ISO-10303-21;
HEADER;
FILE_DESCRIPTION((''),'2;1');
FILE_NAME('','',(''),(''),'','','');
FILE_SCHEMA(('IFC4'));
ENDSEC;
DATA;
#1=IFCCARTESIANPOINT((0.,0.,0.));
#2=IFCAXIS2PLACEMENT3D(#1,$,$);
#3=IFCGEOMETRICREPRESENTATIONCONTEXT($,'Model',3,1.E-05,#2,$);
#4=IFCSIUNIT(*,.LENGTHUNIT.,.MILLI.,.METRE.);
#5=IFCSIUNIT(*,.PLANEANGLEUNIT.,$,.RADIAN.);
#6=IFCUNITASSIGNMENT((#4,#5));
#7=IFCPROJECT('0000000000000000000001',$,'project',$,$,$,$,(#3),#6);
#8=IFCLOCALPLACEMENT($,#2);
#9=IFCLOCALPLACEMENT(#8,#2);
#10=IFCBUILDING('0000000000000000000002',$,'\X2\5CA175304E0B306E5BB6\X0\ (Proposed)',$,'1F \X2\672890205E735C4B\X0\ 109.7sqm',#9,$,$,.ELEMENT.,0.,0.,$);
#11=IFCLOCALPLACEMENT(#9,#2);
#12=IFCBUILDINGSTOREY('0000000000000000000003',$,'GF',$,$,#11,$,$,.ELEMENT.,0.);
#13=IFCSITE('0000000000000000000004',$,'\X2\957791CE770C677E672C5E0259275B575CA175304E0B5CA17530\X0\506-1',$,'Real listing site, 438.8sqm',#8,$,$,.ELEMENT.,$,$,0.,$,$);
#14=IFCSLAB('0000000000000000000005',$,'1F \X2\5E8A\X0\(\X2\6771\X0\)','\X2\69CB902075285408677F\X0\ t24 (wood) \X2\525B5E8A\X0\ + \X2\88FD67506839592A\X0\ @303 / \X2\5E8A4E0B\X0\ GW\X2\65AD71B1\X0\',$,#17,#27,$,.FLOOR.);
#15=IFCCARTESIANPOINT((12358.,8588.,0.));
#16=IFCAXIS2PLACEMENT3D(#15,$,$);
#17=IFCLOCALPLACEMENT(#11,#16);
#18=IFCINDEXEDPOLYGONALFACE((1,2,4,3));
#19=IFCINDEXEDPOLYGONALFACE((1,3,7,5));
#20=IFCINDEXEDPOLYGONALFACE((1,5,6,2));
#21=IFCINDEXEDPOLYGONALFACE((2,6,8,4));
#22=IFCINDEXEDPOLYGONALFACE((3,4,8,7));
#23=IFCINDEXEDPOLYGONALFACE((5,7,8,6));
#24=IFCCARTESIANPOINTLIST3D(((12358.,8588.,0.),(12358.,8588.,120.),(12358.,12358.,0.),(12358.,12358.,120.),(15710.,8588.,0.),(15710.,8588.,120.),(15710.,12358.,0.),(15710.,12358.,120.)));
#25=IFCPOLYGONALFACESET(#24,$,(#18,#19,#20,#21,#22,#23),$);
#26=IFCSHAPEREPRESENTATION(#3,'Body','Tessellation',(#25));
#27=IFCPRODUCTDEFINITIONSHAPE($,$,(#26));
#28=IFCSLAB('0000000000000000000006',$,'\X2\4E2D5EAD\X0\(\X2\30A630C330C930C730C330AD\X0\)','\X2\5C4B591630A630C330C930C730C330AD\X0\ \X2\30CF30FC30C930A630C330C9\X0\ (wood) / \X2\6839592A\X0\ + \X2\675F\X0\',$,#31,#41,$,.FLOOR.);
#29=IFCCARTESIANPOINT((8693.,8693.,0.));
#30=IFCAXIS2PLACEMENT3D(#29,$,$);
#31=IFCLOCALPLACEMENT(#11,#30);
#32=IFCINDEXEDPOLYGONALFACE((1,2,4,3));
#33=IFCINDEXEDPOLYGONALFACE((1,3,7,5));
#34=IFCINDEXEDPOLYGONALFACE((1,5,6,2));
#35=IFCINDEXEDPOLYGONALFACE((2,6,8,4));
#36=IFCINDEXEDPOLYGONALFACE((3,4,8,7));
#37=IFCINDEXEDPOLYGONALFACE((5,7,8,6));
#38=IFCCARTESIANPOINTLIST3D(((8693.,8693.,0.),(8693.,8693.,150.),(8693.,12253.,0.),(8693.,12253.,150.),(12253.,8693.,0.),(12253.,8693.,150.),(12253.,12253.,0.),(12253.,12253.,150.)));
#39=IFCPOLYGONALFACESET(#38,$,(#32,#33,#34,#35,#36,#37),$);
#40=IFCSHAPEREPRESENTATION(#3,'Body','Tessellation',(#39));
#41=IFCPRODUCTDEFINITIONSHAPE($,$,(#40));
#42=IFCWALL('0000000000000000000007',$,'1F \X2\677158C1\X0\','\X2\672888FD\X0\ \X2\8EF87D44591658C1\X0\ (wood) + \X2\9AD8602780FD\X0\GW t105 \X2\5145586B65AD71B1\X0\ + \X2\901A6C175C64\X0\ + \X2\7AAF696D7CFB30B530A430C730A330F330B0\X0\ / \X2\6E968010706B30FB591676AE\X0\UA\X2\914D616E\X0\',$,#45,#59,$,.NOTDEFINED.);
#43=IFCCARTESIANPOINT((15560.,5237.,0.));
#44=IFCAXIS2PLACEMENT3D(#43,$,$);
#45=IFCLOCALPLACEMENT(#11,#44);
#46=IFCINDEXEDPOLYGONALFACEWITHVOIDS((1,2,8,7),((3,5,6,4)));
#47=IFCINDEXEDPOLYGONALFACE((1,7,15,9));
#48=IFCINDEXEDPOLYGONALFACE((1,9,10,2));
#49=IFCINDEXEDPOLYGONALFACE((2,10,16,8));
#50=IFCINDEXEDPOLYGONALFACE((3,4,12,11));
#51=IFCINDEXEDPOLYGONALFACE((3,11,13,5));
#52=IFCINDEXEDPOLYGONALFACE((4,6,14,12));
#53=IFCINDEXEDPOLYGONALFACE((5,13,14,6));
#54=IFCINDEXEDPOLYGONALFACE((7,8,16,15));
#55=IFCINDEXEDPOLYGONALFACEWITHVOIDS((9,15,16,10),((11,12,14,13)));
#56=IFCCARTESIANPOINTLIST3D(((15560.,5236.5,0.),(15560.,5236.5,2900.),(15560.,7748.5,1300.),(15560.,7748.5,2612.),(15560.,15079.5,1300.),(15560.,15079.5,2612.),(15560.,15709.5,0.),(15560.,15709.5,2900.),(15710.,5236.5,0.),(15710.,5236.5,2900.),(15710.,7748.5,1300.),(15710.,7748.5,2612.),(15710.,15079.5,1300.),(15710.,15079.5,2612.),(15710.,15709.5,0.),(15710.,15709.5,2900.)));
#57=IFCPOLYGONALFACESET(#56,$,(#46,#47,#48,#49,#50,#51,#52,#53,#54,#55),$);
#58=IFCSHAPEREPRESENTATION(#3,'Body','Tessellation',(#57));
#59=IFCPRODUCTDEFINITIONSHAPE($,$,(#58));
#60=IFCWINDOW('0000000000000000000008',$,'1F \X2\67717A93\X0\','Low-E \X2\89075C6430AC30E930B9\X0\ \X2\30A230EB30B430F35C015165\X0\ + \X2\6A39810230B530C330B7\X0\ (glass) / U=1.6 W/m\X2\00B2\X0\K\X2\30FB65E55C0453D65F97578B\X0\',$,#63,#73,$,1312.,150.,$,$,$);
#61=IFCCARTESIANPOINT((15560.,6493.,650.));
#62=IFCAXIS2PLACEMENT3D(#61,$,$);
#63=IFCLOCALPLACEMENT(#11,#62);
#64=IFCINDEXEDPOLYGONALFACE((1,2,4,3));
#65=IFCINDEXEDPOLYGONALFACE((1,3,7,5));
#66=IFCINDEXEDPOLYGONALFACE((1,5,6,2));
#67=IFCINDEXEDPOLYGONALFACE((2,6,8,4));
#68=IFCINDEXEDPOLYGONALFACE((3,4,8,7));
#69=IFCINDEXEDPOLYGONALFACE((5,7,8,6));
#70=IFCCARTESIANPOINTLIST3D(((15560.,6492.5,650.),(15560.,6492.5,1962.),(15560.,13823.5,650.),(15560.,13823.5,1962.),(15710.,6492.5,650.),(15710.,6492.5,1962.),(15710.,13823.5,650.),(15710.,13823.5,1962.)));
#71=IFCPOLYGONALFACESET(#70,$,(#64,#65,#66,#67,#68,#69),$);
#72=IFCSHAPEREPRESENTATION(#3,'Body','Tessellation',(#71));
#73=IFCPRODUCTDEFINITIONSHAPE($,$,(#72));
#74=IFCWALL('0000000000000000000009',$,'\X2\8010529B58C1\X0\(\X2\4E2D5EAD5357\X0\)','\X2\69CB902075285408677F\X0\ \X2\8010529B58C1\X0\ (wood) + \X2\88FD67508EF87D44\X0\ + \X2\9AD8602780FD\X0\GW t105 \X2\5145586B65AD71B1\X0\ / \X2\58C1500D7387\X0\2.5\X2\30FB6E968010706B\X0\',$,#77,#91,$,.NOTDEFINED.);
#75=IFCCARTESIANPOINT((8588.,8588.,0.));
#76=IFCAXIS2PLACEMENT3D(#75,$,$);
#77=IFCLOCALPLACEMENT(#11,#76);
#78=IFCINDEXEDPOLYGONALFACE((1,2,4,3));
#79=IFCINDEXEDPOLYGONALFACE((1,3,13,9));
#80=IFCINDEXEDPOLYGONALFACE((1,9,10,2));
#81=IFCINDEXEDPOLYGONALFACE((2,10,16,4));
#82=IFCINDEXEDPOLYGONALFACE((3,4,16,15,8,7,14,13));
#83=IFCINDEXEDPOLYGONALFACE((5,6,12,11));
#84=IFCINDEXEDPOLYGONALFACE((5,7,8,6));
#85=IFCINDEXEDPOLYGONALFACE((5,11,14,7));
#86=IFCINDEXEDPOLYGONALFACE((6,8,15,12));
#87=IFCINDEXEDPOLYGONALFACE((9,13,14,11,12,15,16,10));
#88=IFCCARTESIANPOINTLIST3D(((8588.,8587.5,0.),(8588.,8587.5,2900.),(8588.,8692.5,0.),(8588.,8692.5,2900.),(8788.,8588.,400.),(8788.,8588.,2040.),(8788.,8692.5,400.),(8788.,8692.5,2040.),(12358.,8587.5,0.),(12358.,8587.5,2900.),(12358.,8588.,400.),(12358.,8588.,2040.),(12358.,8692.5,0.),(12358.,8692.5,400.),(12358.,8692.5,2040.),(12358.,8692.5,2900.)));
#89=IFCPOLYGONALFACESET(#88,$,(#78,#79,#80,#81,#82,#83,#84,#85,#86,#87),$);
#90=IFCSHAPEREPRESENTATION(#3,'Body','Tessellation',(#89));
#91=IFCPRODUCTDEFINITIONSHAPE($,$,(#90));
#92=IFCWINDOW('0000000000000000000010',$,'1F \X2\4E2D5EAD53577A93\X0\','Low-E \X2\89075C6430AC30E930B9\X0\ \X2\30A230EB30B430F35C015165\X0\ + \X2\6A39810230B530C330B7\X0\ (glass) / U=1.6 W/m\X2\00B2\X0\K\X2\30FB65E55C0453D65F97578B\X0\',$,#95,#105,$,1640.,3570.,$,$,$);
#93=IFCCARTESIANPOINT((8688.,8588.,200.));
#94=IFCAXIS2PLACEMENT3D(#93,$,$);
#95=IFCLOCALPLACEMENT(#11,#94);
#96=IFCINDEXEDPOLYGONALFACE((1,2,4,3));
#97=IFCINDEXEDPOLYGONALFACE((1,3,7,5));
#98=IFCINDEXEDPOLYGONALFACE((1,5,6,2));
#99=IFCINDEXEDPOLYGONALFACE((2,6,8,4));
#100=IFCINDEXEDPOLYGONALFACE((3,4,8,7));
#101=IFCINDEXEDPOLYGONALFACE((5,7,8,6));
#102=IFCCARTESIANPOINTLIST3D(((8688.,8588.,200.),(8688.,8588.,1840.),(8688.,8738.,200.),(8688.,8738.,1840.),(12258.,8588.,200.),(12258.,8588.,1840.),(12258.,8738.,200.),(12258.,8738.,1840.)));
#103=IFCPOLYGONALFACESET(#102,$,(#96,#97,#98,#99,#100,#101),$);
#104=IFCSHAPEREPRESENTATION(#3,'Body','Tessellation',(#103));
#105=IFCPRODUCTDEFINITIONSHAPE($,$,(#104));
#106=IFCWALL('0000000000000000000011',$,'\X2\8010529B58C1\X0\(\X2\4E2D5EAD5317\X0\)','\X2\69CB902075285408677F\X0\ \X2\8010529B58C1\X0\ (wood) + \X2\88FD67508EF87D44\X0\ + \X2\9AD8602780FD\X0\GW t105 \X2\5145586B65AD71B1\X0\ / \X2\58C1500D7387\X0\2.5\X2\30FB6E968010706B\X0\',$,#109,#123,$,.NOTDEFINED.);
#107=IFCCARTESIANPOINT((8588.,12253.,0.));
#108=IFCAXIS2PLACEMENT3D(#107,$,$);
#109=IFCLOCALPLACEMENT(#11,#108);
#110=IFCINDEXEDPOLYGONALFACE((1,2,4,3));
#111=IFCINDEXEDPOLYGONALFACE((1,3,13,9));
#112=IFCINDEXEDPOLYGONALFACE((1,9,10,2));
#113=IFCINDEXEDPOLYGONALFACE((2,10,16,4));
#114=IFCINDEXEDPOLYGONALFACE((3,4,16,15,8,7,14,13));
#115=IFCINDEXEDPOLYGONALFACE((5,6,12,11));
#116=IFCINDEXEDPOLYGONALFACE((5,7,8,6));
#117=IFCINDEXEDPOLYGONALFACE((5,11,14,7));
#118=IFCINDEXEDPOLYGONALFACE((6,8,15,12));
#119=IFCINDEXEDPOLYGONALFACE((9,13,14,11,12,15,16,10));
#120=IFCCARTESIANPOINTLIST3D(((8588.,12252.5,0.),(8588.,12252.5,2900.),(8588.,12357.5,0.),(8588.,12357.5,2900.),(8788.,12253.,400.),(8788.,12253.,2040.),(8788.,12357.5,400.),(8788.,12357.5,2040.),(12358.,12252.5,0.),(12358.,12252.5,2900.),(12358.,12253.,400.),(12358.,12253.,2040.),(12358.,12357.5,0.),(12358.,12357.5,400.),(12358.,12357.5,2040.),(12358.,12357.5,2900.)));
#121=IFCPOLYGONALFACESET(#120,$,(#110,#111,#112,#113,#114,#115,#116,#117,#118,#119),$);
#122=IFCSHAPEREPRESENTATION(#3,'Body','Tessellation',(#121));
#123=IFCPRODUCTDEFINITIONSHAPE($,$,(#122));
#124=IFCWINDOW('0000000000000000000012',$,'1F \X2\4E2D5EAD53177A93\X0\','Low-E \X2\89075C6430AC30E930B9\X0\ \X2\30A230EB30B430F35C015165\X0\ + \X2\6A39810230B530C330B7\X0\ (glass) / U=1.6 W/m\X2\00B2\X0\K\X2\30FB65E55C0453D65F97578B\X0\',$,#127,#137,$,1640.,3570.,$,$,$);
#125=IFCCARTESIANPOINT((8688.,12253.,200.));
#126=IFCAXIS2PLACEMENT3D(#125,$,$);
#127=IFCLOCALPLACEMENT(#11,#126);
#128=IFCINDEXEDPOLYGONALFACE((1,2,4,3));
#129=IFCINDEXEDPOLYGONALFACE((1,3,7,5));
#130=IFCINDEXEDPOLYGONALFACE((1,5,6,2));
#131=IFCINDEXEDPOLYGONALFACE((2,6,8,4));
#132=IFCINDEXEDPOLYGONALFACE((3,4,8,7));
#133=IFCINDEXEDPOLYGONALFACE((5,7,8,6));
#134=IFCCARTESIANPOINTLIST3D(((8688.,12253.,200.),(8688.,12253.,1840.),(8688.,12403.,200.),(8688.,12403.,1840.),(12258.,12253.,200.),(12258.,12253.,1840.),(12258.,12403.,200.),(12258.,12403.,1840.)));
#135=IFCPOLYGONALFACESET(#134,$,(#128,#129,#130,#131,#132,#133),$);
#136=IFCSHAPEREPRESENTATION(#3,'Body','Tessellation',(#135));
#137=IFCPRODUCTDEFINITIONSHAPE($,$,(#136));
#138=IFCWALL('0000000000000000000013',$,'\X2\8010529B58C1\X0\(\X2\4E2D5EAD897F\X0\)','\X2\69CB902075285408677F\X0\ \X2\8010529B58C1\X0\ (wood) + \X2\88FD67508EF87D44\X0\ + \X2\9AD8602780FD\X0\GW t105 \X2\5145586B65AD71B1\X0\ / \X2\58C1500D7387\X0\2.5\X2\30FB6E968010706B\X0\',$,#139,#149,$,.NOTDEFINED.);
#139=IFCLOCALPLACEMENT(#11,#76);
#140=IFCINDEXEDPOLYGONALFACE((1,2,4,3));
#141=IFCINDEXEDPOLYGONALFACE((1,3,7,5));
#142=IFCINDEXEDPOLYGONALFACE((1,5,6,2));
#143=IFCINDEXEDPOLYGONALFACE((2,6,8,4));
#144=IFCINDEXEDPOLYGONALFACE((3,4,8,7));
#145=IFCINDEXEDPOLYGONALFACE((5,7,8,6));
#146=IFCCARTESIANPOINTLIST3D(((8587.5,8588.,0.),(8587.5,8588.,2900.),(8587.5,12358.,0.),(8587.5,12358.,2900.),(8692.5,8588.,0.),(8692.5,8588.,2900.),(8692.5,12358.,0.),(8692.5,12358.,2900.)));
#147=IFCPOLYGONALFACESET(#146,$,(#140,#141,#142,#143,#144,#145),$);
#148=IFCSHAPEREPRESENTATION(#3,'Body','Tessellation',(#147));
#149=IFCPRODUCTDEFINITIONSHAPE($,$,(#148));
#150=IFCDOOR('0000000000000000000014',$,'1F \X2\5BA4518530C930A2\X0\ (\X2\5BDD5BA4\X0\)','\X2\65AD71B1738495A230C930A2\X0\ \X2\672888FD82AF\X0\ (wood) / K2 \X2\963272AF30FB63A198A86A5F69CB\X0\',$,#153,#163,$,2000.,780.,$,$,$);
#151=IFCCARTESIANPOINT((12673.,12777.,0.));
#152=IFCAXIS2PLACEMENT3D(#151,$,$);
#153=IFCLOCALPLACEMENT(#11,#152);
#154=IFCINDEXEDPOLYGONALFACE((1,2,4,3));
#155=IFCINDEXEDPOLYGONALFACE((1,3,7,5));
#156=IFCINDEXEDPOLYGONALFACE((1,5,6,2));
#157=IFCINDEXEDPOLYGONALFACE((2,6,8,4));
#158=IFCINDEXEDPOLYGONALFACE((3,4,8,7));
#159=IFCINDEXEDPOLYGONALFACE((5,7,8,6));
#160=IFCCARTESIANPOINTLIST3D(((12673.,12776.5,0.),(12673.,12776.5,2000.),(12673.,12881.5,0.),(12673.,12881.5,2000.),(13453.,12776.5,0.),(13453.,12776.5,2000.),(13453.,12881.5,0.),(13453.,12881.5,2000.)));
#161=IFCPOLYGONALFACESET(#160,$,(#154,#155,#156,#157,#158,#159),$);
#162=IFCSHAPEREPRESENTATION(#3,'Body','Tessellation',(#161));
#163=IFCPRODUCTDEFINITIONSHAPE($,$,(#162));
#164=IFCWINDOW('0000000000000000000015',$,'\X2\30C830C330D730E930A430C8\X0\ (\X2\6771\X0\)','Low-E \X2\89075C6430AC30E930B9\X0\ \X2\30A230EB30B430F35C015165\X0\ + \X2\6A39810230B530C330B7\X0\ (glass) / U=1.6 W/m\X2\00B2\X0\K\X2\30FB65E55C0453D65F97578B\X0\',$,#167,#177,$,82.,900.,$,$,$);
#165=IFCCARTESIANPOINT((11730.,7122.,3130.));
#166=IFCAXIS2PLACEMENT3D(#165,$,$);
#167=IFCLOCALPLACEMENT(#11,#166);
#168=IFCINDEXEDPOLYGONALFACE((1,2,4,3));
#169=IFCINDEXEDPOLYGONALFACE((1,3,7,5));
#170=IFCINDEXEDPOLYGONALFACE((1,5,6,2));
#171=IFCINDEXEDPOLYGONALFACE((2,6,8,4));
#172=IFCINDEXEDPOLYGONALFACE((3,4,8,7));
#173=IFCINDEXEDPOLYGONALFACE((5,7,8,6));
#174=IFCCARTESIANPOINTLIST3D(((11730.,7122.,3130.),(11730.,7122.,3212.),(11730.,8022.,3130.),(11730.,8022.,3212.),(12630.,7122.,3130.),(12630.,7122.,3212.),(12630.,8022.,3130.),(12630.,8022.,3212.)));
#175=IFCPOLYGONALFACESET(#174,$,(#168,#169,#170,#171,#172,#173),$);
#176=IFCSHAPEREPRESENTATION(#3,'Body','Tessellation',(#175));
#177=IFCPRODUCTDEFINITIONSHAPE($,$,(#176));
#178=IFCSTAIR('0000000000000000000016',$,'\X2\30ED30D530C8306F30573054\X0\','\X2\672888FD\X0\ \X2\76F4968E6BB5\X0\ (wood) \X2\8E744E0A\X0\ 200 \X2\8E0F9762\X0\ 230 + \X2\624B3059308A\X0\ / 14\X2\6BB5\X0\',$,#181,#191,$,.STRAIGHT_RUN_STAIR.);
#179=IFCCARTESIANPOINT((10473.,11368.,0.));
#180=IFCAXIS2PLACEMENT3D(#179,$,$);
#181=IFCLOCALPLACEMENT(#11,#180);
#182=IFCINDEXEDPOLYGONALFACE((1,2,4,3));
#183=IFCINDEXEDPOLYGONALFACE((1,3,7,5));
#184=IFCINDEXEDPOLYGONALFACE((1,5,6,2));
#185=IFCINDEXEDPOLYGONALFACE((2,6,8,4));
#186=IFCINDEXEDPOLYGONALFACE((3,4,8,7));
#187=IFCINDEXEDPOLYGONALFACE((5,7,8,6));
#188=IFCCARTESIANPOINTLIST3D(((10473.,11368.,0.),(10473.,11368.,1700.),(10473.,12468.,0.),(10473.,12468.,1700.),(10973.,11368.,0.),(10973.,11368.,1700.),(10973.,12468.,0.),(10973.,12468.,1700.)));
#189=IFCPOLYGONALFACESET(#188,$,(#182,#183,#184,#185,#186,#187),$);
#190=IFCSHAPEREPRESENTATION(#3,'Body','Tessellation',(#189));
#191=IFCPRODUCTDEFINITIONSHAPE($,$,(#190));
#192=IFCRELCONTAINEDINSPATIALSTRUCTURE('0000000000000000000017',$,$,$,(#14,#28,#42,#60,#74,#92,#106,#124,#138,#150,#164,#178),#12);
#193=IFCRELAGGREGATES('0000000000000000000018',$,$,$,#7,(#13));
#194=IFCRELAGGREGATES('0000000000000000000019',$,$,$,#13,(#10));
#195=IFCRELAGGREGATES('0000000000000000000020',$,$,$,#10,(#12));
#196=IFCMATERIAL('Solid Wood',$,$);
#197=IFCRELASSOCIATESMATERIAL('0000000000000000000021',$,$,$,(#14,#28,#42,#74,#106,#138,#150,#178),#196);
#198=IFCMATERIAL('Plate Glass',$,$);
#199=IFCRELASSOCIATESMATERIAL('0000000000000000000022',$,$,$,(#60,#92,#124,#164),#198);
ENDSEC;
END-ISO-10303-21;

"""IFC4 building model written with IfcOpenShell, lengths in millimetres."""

from ifc_helpers import new_model, si_unit, frame, frame_2d, origin, place, context, project, spatial, rectangle, extrude, material, element, fill, save


model = new_model("IFC4")

# Units and contexts
model_context = context("Model", 3, precision=1e-05, world=origin())
ifc_project = project(units=[si_unit("LENGTHUNIT", "METRE", prefix="MILLI"), si_unit("PLANEANGLEUNIT", "RADIAN")], contexts=[model_context])

# Site, building, storey
site_placement = place(None, origin())
site = spatial("IfcSite", under=ifc_project, at=site_placement, Name="長野県松本市大字岡田下岡田506-1", ObjectType="Real listing site, 438.8sqm", CompositionType="ELEMENT", RefElevation=0.0)
building_placement = place(site_placement, origin())
building = spatial("IfcBuilding", under=site, at=building_placement, Name="岡田下の家 (Proposed)", ObjectType="1F 木造平屋 109.7sqm", CompositionType="ELEMENT", ElevationOfRefHeight=0.0, ElevationOfTerrain=0.0)
storey_placement = place(building_placement, origin())
storey = spatial("IfcBuildingStorey", under=building, at=storey_placement, Name="GF", CompositionType="ELEMENT", Elevation=0.0)

# Slabs
ifc_material_1 = material(Name="Solid Wood")
slab_1_placement = place(storey_placement, frame((12358.0, 8588.0, 0.0)))
element("IfcSlab", 1, at=slab_1_placement, inside=storey, material=ifc_material_1, Name="1F 床(東)", Description="構造用合板 t24 (wood) 剛床 + 製材根太 @303 / 床下 GW断熱", PredefinedType="FLOOR", context=model_context, shape_type="SweptSolid", body=[
    extrude(rectangle(XDim=3352.0, YDim=3770.0, at=frame_2d((1676.0, 1885.0))), frame((12358.0, 8588.0, 0.0)), (0.0, 0.0, 1.0), 120.0),
])
slab_2_placement = place(storey_placement, frame((8693.0, 8693.0, 0.0)))
element("IfcSlab", 2, at=slab_2_placement, inside=storey, material=ifc_material_1, Name="中庭(ウッドデッキ)", Description="屋外ウッドデッキ ハードウッド (wood) / 根太 + 束", PredefinedType="FLOOR", context=model_context, shape_type="SweptSolid", body=[
    extrude(rectangle(XDim=3560.0, YDim=3560.0, at=frame_2d((1780.0, 1780.0))), frame((8693.0, 8693.0, 0.0)), (0.0, 0.0, 1.0), 150.0),
])

# Walls, openings, windows
wall_1_placement = place(storey_placement, frame((15560.0, 5237.0, 0.0)))
wall_1 = element("IfcWall", 3, at=wall_1_placement, inside=storey, material=ifc_material_1, Name="1F 東壁", Description="木製 軸組外壁 (wood) + 高性能GW t105 充填断熱 + 通気層 + 窯業系サイディング / 準耐火・外皮UA配慮", PredefinedType="NOTDEFINED", context=model_context, shape_type="SweptSolid", body=[
    extrude(rectangle(XDim=150.0, YDim=10473.0, at=frame_2d((75.0, 5236.0))), frame((15560.0, 5237.0, 0.0)), (0.0, 0.0, 1.0), 2900.0),
])
opening_1_placement = place(storey_placement, frame((15560.0, 6493.0, 650.0)))
opening_1 = element("IfcOpeningElement", 4, at=opening_1_placement, cuts=wall_1, PredefinedType="NOTDEFINED", context=model_context, shape_type="SweptSolid", body=[
    extrude(rectangle(XDim=150.0, YDim=7331.0, at=frame_2d((75.0, 3665.0))), frame((15560.0, 6493.0, 650.0)), (0.0, 0.0, 1.0), 1312.0),
])
ifc_material_2 = material(Name="Plate Glass")
window_1_placement = place(storey_placement, frame((15560.0, 6493.0, 650.0)))
window_1 = element("IfcWindow", 5, at=window_1_placement, inside=storey, material=ifc_material_2, Name="1F 東窓", Description="Low-E 複層ガラス アルゴン封入 + 樹脂サッシ (glass) / U=1.6 W/m²K・日射取得型", OverallHeight=1312.0, OverallWidth=150.0, context=model_context, shape_type="SweptSolid", body=[
    extrude(rectangle(XDim=150.0, YDim=7331.0, at=frame_2d((75.0, 3665.0))), frame((15560.0, 6493.0, 650.0)), (0.0, 0.0, 1.0), 1312.0),
])
fill(opening_1, window_1)
wall_2_placement = place(storey_placement, frame((8588.0, 8588.0, 0.0)))
wall_2 = element("IfcWall", 6, at=wall_2_placement, inside=storey, material=ifc_material_1, Name="耐力壁(中庭南)", Description="構造用合板 耐力壁 (wood) + 製材軸組 + 高性能GW t105 充填断熱 / 壁倍率2.5・準耐火", PredefinedType="NOTDEFINED", context=model_context, shape_type="SweptSolid", body=[
    extrude(rectangle(XDim=3770.0, YDim=105.0, at=frame_2d((1885.0, 52.0))), frame((8588.0, 8588.0, 0.0)), (0.0, 0.0, 1.0), 2900.0),
])
opening_2_placement = place(storey_placement, frame((8688.0, 8588.0, 200.0)))
opening_2 = element("IfcOpeningElement", 7, at=opening_2_placement, cuts=wall_2, PredefinedType="NOTDEFINED", context=model_context, shape_type="SweptSolid", body=[
    extrude(rectangle(XDim=3570.0, YDim=150.0, at=frame_2d((1785.0, 75.0))), frame((8688.0, 8588.0, 200.0)), (0.0, 0.0, 1.0), 1640.0),
])
window_2_placement = place(storey_placement, frame((8688.0, 8588.0, 200.0)))
window_2 = element("IfcWindow", 8, at=window_2_placement, inside=storey, material=ifc_material_2, Name="1F 中庭南窓", Description="Low-E 複層ガラス アルゴン封入 + 樹脂サッシ (glass) / U=1.6 W/m²K・日射取得型", OverallHeight=1640.0, OverallWidth=3570.0, context=model_context, shape_type="SweptSolid", body=[
    extrude(rectangle(XDim=3570.0, YDim=150.0, at=frame_2d((1785.0, 75.0))), frame((8688.0, 8588.0, 200.0)), (0.0, 0.0, 1.0), 1640.0),
])
fill(opening_2, window_2)
wall_3_placement = place(storey_placement, frame((8588.0, 12253.0, 0.0)))
wall_3 = element("IfcWall", 9, at=wall_3_placement, inside=storey, material=ifc_material_1, Name="耐力壁(中庭北)", Description="構造用合板 耐力壁 (wood) + 製材軸組 + 高性能GW t105 充填断熱 / 壁倍率2.5・準耐火", PredefinedType="NOTDEFINED", context=model_context, shape_type="SweptSolid", body=[
    extrude(rectangle(XDim=3770.0, YDim=105.0, at=frame_2d((1885.0, 52.0))), frame((8588.0, 12253.0, 0.0)), (0.0, 0.0, 1.0), 2900.0),
])
opening_3_placement = place(storey_placement, frame((8688.0, 12253.0, 200.0)))
opening_3 = element("IfcOpeningElement", 10, at=opening_3_placement, cuts=wall_3, PredefinedType="NOTDEFINED", context=model_context, shape_type="SweptSolid", body=[
    extrude(rectangle(XDim=3570.0, YDim=150.0, at=frame_2d((1785.0, 75.0))), frame((8688.0, 12253.0, 200.0)), (0.0, 0.0, 1.0), 1640.0),
])
window_3_placement = place(storey_placement, frame((8688.0, 12253.0, 200.0)))
window_3 = element("IfcWindow", 11, at=window_3_placement, inside=storey, material=ifc_material_2, Name="1F 中庭北窓", Description="Low-E 複層ガラス アルゴン封入 + 樹脂サッシ (glass) / U=1.6 W/m²K・日射取得型", OverallHeight=1640.0, OverallWidth=3570.0, context=model_context, shape_type="SweptSolid", body=[
    extrude(rectangle(XDim=3570.0, YDim=150.0, at=frame_2d((1785.0, 75.0))), frame((8688.0, 12253.0, 200.0)), (0.0, 0.0, 1.0), 1640.0),
])
fill(opening_3, window_3)

# Wall
wall_4_placement = place(storey_placement, frame((8588.0, 8588.0, 0.0)))
element("IfcWall", 12, at=wall_4_placement, inside=storey, material=ifc_material_1, Name="耐力壁(中庭西)", Description="構造用合板 耐力壁 (wood) + 製材軸組 + 高性能GW t105 充填断熱 / 壁倍率2.5・準耐火", PredefinedType="NOTDEFINED", context=model_context, shape_type="SweptSolid", body=[
    extrude(rectangle(XDim=105.0, YDim=3770.0, at=frame_2d((52.0, 1885.0))), frame((8588.0, 8588.0, 0.0)), (0.0, 0.0, 1.0), 2900.0),
])

# Door
door_placement = place(storey_placement, frame((12673.0, 12777.0, 0.0)))
element("IfcDoor", 13, at=door_placement, inside=storey, material=ifc_material_1, Name="1F 室内ドア (寝室)", Description="断熱玄関ドア 木製芯 (wood) / K2 防犯・採風機構", OverallHeight=2000.0, OverallWidth=780.0, context=model_context, shape_type="SweptSolid", body=[
    extrude(rectangle(XDim=780.0, YDim=105.0, at=frame_2d((390.0, 52.0))), frame((12673.0, 12777.0, 0.0)), (0.0, 0.0, 1.0), 2000.0),
])

# Window
window_4_placement = place(storey_placement, frame((11730.0, 7122.0, 3130.0)))
element("IfcWindow", 14, at=window_4_placement, inside=storey, material=ifc_material_2, Name="トップライト (東)", Description="Low-E 複層ガラス アルゴン封入 + 樹脂サッシ (glass) / U=1.6 W/m²K・日射取得型", OverallHeight=82.0, OverallWidth=900.0, context=model_context, shape_type="SweptSolid", body=[
    extrude(rectangle(XDim=900.0, YDim=900.0, at=frame_2d((450.0, 450.0))), frame((11730.0, 7122.0, 3130.0)), (0.0, 0.0, 1.0), 82.0),
])

# Stair
stair_placement = place(storey_placement, frame((10473.0, 11368.0, 0.0)))
element("IfcStair", 15, at=stair_placement, inside=storey, material=ifc_material_1, Name="ロフトはしご", Description="木製 直階段 (wood) 蹴上 200 踏面 230 + 手すり / 14段", PredefinedType="STRAIGHT_RUN_STAIR", context=model_context, shape_type="SweptSolid", body=[
    extrude(rectangle(XDim=500.0, YDim=1100.0, at=frame_2d((250.0, 550.0))), frame((10473.0, 11368.0, 0.0)), (0.0, 0.0, 1.0), 1700.0),
])

save(model, "model.ifc")
